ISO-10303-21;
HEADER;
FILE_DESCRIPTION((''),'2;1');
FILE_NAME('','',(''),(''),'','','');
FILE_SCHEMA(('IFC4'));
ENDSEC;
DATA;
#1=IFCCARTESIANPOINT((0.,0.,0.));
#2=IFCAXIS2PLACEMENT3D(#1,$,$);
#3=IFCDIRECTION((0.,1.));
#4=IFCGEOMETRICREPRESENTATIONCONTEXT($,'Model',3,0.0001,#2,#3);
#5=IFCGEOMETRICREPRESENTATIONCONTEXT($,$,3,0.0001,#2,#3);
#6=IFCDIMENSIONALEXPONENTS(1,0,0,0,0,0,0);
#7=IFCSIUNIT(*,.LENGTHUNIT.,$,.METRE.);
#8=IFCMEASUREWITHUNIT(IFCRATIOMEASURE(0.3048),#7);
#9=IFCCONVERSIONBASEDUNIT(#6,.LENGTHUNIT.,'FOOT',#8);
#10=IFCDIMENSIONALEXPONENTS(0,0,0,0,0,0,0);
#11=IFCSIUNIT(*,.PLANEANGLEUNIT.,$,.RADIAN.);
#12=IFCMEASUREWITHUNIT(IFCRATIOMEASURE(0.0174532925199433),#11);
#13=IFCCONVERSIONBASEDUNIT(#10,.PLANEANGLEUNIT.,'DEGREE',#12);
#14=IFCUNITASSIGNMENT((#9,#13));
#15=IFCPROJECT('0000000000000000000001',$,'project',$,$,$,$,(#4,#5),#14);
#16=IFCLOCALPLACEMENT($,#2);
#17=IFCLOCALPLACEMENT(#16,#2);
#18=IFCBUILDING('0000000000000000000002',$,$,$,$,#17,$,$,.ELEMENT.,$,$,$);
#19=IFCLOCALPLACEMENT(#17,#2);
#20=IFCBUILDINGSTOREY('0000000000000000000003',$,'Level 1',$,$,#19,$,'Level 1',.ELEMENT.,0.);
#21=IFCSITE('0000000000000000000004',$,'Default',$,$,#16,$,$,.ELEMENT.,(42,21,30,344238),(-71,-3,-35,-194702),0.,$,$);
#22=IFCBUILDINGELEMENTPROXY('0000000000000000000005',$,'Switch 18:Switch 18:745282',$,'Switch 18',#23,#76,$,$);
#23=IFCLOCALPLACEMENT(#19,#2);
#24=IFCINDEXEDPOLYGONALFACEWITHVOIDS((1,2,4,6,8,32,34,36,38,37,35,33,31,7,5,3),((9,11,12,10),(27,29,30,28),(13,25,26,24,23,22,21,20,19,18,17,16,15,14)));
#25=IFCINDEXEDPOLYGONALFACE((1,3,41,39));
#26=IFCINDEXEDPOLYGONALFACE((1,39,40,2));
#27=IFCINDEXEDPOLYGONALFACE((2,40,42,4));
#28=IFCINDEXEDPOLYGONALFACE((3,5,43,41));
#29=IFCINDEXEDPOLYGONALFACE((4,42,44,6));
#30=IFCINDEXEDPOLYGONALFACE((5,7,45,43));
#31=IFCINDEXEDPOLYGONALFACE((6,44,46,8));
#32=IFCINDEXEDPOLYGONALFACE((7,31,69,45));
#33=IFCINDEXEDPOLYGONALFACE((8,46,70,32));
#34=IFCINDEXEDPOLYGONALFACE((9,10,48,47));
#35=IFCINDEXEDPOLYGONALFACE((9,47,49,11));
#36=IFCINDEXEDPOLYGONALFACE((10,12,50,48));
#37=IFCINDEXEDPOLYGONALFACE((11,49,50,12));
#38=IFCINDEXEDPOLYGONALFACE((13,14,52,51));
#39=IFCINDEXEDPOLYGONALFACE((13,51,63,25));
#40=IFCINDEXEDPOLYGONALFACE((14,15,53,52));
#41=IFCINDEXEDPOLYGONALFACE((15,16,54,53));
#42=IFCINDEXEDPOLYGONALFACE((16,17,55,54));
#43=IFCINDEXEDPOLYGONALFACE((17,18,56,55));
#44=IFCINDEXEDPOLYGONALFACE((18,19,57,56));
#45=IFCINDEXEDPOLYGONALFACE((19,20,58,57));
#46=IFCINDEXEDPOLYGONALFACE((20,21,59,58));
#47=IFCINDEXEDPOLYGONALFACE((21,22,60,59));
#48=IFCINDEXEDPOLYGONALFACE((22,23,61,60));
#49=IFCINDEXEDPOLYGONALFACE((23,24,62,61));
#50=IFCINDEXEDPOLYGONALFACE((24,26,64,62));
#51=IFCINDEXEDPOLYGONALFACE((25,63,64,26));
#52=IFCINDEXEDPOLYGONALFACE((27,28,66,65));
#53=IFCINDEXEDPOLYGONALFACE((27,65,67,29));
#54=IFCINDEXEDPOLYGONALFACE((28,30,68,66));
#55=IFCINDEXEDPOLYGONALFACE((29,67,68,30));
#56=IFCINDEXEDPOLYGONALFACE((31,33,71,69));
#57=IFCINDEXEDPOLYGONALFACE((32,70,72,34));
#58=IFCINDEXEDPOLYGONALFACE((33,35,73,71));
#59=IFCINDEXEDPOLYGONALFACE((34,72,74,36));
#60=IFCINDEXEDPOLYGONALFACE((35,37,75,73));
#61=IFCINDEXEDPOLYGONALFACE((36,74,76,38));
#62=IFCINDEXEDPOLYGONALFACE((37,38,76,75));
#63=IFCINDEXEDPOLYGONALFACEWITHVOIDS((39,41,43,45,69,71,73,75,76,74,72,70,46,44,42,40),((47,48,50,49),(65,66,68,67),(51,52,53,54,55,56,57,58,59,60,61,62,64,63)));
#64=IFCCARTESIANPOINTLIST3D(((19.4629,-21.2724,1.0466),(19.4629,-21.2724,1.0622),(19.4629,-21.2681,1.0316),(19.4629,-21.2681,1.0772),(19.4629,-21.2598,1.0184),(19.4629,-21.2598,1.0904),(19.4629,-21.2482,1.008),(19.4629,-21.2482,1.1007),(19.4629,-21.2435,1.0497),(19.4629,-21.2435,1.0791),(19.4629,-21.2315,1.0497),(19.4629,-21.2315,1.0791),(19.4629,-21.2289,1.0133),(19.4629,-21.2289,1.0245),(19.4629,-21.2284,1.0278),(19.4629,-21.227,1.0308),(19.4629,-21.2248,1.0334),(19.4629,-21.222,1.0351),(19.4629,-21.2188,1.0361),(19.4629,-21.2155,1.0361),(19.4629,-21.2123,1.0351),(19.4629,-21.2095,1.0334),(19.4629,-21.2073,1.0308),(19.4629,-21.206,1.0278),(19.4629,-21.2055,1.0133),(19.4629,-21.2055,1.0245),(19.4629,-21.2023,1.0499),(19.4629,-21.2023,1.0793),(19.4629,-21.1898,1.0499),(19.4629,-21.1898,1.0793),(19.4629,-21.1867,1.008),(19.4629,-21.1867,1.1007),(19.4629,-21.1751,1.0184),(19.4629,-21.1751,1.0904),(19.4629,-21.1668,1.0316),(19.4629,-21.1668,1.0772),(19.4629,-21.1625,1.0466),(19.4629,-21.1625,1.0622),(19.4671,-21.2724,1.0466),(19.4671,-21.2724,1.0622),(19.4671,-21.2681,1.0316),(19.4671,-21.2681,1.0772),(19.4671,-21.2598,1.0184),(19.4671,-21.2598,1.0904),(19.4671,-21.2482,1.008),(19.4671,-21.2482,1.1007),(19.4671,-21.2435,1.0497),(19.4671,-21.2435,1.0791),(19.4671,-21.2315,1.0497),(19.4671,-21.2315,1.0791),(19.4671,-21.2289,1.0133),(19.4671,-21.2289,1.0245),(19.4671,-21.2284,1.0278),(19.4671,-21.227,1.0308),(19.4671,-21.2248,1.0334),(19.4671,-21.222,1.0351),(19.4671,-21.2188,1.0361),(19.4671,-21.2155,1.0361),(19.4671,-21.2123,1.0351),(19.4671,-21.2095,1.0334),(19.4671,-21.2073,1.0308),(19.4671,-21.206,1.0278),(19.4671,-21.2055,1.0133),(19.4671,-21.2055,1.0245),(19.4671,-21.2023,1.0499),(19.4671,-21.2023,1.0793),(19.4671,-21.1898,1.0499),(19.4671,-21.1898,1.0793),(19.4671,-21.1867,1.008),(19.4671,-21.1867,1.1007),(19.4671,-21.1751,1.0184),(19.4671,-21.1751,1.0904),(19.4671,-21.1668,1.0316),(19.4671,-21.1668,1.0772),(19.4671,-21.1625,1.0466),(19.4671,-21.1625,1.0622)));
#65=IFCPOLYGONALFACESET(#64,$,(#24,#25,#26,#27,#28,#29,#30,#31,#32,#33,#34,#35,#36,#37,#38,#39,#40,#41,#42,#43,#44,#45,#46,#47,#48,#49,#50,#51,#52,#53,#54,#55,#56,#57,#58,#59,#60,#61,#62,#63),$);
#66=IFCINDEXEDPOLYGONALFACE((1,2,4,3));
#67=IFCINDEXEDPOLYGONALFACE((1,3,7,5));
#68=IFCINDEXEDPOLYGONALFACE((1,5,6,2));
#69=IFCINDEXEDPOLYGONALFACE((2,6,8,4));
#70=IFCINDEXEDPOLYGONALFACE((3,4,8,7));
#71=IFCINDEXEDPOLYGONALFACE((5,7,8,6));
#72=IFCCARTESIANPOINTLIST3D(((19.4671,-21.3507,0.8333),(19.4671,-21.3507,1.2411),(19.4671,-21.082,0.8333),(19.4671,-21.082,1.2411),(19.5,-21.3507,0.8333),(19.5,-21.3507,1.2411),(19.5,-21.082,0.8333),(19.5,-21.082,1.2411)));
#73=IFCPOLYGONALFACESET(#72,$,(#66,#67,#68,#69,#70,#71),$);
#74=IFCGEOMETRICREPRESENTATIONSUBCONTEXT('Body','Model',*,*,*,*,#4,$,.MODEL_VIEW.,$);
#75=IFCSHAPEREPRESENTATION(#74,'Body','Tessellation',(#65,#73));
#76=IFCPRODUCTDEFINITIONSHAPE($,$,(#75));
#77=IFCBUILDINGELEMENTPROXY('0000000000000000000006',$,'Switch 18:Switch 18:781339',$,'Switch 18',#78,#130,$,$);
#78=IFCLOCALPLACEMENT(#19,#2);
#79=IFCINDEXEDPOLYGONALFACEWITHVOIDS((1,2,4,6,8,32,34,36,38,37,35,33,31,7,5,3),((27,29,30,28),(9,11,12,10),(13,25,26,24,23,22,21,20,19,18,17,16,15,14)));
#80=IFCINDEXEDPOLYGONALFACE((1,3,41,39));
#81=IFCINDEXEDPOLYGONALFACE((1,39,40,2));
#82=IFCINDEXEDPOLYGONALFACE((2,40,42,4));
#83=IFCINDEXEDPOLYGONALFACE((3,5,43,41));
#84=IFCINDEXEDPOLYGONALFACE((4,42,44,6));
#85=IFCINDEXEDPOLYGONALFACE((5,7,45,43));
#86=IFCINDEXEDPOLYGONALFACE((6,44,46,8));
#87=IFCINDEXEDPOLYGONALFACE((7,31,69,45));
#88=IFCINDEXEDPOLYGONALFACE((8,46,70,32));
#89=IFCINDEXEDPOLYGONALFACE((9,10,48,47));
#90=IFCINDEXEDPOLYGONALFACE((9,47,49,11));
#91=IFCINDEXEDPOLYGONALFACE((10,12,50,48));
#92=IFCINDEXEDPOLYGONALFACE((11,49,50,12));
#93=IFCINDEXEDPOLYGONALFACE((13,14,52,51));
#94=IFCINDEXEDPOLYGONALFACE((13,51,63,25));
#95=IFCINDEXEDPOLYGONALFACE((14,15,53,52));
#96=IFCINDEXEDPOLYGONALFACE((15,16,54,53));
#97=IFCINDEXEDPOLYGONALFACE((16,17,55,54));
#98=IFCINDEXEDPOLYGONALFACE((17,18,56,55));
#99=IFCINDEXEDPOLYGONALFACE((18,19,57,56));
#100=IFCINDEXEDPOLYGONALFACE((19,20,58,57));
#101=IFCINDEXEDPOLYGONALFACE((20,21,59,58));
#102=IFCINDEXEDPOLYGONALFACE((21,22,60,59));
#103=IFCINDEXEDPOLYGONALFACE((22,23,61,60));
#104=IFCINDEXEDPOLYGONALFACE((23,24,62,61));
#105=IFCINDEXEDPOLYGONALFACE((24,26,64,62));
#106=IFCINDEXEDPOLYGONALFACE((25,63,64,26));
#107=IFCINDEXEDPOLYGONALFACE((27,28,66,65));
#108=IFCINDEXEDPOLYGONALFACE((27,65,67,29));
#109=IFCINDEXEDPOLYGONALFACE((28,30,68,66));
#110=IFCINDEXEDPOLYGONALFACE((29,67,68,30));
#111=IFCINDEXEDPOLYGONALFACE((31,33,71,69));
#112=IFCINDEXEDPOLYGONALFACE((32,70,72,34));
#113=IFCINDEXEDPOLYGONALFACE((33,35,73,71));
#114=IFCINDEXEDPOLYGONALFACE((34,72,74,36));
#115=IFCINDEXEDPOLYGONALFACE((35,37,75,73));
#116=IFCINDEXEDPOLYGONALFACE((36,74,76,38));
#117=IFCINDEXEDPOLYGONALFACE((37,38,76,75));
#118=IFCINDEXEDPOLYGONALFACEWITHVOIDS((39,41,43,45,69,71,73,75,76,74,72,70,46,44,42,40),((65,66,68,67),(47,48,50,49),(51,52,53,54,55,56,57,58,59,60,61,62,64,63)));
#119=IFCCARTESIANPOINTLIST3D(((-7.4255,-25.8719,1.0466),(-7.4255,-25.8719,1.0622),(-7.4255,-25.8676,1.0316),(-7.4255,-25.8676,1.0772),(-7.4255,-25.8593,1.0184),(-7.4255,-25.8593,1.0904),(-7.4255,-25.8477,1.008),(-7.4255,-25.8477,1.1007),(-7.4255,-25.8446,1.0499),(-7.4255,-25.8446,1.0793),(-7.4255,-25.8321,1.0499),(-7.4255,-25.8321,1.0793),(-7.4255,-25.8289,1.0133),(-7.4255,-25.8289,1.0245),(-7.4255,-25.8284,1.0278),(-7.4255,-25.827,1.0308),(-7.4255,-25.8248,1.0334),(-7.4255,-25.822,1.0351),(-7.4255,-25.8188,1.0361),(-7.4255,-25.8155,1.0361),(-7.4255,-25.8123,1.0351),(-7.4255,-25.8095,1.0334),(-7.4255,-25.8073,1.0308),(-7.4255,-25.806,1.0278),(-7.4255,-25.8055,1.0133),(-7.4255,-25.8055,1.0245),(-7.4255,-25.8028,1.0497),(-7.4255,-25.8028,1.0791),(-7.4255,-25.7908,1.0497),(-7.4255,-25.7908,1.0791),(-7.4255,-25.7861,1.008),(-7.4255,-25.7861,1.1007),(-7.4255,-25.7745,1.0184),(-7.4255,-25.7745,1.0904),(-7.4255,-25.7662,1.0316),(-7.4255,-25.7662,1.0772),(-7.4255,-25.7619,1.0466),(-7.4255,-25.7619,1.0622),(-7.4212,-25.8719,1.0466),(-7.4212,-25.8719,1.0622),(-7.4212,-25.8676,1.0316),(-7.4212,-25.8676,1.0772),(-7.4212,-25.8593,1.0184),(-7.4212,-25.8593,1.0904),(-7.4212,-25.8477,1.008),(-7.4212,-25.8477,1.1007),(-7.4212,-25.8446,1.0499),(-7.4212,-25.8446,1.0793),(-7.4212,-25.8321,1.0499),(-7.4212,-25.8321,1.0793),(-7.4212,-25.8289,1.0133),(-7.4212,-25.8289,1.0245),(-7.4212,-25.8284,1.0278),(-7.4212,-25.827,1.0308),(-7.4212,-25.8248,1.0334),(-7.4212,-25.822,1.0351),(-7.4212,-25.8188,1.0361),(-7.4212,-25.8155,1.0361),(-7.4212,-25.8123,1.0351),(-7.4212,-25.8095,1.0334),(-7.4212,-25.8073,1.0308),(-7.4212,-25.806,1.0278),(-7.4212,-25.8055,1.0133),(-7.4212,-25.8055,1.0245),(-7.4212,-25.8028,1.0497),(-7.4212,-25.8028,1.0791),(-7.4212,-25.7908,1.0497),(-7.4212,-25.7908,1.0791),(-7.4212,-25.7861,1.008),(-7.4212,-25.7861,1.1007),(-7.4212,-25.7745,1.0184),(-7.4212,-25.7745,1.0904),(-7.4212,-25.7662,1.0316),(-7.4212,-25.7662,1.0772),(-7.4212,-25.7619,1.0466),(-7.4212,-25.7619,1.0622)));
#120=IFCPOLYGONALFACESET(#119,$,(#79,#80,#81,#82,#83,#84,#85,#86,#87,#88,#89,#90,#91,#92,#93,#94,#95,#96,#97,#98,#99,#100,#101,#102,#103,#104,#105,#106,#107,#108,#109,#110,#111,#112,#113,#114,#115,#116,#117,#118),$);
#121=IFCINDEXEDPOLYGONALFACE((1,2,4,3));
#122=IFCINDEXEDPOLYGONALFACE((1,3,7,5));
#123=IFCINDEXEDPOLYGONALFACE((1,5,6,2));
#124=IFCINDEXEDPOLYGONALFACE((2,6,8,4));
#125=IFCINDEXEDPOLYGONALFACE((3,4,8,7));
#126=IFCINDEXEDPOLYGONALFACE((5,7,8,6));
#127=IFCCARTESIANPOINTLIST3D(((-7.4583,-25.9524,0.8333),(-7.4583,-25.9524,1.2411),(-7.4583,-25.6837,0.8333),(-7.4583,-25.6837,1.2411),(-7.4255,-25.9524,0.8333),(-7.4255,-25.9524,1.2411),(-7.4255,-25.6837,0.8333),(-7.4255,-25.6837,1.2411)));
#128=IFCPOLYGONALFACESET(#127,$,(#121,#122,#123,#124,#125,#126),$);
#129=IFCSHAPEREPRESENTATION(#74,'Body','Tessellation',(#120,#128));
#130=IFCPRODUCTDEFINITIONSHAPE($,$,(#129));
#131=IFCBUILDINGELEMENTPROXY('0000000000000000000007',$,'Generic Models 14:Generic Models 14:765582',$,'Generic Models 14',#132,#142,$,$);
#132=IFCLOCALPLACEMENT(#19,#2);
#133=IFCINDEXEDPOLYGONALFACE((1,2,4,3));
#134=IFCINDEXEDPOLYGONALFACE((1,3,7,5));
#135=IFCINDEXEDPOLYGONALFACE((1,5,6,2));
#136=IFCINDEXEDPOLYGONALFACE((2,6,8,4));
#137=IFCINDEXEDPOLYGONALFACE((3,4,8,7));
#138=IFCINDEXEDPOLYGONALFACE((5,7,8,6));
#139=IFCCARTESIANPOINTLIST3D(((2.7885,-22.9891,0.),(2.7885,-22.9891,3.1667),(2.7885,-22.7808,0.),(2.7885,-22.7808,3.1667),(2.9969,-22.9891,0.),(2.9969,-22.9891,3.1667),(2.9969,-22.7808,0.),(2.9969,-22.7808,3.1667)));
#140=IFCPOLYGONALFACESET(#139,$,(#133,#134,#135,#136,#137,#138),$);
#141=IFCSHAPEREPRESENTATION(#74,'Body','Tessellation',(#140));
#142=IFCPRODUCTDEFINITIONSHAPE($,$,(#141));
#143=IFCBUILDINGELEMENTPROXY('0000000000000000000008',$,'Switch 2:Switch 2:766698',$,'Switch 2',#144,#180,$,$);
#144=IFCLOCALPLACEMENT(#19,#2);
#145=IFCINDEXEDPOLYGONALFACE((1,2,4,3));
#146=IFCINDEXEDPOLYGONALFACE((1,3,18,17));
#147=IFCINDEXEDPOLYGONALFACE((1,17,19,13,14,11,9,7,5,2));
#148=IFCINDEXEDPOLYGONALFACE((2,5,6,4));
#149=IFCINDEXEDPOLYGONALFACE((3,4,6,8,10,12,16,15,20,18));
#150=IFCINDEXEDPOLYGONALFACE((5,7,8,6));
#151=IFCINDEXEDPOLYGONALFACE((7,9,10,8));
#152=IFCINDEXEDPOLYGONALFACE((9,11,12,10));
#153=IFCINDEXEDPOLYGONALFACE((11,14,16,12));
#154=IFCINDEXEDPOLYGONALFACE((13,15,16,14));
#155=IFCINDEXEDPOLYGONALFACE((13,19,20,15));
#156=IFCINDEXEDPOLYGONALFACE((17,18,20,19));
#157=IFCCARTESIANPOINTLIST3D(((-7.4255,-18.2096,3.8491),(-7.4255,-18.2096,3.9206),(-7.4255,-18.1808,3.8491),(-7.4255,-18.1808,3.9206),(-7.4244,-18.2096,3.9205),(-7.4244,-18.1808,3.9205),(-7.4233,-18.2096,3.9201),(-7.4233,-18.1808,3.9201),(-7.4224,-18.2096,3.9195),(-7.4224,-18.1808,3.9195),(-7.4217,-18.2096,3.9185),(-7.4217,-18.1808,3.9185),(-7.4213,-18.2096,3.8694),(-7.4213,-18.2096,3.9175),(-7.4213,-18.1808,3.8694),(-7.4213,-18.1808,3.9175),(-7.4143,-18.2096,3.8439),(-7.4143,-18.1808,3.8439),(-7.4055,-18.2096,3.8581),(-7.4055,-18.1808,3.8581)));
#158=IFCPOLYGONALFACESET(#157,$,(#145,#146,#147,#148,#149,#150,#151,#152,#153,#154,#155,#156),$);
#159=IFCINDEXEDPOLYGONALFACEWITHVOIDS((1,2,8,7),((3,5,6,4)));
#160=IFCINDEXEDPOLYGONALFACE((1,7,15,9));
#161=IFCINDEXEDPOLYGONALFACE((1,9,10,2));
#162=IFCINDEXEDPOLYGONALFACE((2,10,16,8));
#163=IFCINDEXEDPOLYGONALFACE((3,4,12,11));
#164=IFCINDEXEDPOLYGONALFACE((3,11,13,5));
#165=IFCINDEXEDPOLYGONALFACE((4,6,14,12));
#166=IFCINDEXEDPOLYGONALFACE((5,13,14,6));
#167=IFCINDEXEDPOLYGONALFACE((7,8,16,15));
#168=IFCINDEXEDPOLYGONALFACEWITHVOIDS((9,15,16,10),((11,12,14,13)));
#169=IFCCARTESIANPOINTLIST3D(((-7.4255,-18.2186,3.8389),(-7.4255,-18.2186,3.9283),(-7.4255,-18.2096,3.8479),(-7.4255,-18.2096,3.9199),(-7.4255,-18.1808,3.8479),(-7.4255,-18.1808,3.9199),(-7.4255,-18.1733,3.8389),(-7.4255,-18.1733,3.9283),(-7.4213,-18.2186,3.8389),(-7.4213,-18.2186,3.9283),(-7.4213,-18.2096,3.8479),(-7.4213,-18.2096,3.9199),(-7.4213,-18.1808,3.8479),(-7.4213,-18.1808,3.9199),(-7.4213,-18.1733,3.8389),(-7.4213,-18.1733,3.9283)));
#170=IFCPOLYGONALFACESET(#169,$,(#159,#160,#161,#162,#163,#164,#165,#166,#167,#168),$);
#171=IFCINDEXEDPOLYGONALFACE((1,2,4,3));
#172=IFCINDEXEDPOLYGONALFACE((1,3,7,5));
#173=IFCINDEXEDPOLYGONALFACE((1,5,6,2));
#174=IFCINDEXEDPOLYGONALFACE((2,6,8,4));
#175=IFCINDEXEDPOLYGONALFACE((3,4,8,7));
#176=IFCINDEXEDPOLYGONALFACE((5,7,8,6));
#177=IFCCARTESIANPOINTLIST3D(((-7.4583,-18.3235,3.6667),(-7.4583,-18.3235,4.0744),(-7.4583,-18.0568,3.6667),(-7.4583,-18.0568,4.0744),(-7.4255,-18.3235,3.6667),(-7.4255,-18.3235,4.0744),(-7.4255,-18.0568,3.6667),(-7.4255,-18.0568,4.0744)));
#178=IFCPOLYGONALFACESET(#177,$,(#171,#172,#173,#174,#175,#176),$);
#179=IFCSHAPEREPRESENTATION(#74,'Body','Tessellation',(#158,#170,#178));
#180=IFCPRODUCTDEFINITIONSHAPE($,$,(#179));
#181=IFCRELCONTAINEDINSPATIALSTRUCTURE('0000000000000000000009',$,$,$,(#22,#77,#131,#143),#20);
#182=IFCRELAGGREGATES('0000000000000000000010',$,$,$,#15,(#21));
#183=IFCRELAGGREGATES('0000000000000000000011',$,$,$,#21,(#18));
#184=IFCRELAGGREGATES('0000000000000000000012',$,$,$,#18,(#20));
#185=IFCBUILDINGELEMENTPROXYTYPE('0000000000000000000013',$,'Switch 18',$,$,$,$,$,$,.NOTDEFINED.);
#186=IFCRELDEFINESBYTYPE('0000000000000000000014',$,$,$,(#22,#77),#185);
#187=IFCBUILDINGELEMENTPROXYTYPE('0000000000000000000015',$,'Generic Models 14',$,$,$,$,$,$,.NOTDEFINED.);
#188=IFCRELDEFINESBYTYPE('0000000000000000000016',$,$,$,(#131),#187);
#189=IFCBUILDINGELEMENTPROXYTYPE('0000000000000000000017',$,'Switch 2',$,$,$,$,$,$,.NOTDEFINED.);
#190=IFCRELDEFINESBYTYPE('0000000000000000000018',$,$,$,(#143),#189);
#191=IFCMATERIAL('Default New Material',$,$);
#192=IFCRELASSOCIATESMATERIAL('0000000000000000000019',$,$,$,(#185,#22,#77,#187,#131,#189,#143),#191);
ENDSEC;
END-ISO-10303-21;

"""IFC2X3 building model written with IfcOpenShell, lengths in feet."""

from ifc_helpers import new_model, entity, si_unit, converted_unit, direction, frame, frame_2d, origin, origin_2d_with_axis, place, context, subcontext, project, spatial, polyline, circle_curve, parameter, trimmed, segment, composite_curve, rectangle, outline, extrude, source, transform, mapped, material, type_object, type_shapes, element, save


model = new_model("IFC2X3")

# Units and contexts
model_context = context("Model", 3, precision=0.0001, world=origin(), true_north=direction((0.0, 1.0)))
context_of_model = context(None, 3, precision=0.0001, world=origin(), true_north=direction((0.0, 1.0)))
body_context = subcontext(model_context, "Body", "Model", "MODEL_VIEW")
ifc_project = project(units=[converted_unit("LENGTHUNIT", "FOOT", entity("IfcRatioMeasure", 0.3048), si_unit("LENGTHUNIT", "METRE"), dimensions=[1, 0, 0, 0, 0, 0, 0]), converted_unit("PLANEANGLEUNIT", "DEGREE", entity("IfcRatioMeasure", 0.0174532925199433), si_unit("PLANEANGLEUNIT", "RADIAN"), dimensions=[0, 0, 0, 0, 0, 0, 0])], contexts=[model_context, context_of_model])

# Site, building, storey
site_placement = place(None, origin())
site = spatial("IfcSite", under=ifc_project, at=site_placement, Name="Default", CompositionType="ELEMENT", RefLatitude=(42, 21, 30, 344238), RefLongitude=(-71, -3, -35, -194702), RefElevation=0.0)
building_placement = place(site_placement, origin())
building = spatial("IfcBuilding", under=site, at=building_placement, CompositionType="ELEMENT")
storey_placement = place(building_placement, origin())
storey = spatial("IfcBuildingStorey", under=building, at=storey_placement, Name="Level 1", LongName="Level 1", CompositionType="ELEMENT", Elevation=0.0)

# Shared definitions
ifc_material = material(Name="Default New Material")

# Building element proxies
building_element_proxy_type_1 = type_object("IfcBuildingElementProxyType", Name="Switch 18", PredefinedType="NOTDEFINED", material=ifc_material)
shared_shape_1 = source(origin(), body_context, "Body", "SweptSolid", [
    extrude(outline(composite_curve([segment(polyline([(-0.0308, -0.0464), (0.0308, -0.0464)]), True, "CONTINUOUS"), segment(trimmed(circle_curve(frame_2d((-0.0003, 0.0), x_axis=(-1.0, 0.0)), 0.0558), [parameter(123.794741)], [parameter(236.205259)], True, "PARAMETER"), True, "CONTINUOUS"), segment(polyline([(0.0308, 0.0464), (-0.0308, 0.0464)]), True, "CONTINUOUS"), segment(trimmed(circle_curve(frame_2d((0.0003, 0.0), x_axis=(1.0, 0.0)), 0.0558), [parameter(123.794741)], [parameter(236.205259)], True, "PARAMETER"), True, "CONTINUOUS")], self_intersect=False), holes=[polyline([(0.0141, 0.0247), (0.026, 0.0247), (0.026, -0.0047), (0.0141, -0.0047), (0.0141, 0.0247)]), polyline([(-0.0152, 0.0249), (-0.0152, -0.0045), (-0.0277, -0.0045), (-0.0277, 0.0249), (-0.0152, 0.0249)]), composite_curve([segment(polyline([(-0.012, -0.0411), (-0.012, -0.0299)]), True, "CONTINUOUS"), segment(trimmed(circle_curve(frame_2d((-0.0003, -0.0299), x_axis=(-1.0, 0.0)), 0.0117), [parameter(180.0)], [parameter(0.0)], True, "PARAMETER"), False, "CONTINUOUS"), segment(polyline([(0.0114, -0.0299), (0.0114, -0.0411)]), True, "CONTINUOUS"), segment(polyline([(0.0114, -0.0411), (-0.012, -0.0411)]), True, "CONTINUOUS")], self_intersect=False)]), frame((-0.0011, 0.0329, 0.2211), z_axis=(0.0, 1.0, 0.0), x_axis=(-1.0, 0.0, 0.0)), (0.0, 0.0, 1.0), 0.0042),
    extrude(rectangle(XDim=0.0329, YDim=0.2687, at=origin_2d_with_axis()), frame((0.0, 0.0164, 0.0), z_axis=(0.0, 0.0, 1.0), x_axis=(0.0, -1.0, 0.0)), (0.0, 0.0, 1.0), 0.4078),
])
type_shapes(building_element_proxy_type_1, [shared_shape_1])
for number, where, z_axis, x_axis, name in (
    (1, (19.5, -21.2163, 0.8333), (0.0, 0.0, 1.0), (0.0, 1.0, 0.0), "Switch 18:Switch 18:745282"),
    (2, (-7.4583, -25.818, 0.8333), (0.0, 0.0, 1.0), (0.0, -1.0, 0.0), "Switch 18:Switch 18:781339"),
):
    element("IfcBuildingElementProxy", number, at=place(storey_placement, frame(where, z_axis=z_axis, x_axis=x_axis)), inside=storey, type_object=building_element_proxy_type_1, material=ifc_material, Name=name, ObjectType="Switch 18", context=body_context, shape_type="MappedRepresentation", body=[
        mapped(shared_shape_1, transform((0.0, 0.0, 0.0), scale=1.0)),
    ])
building_element_proxy_type_2 = type_object("IfcBuildingElementProxyType", Name="Generic Models 14", PredefinedType="NOTDEFINED", material=ifc_material)
shared_shape_2 = source(origin(), body_context, "Body", "SweptSolid", [
    extrude(rectangle(XDim=0.2083, YDim=0.2083, at=frame_2d((0.0, 0.0), x_axis=(1.0, 0.0))), frame((0.1042, 0.1042, 0.0), z_axis=(0.0, 0.0, 1.0), x_axis=(0.0, 1.0, 0.0)), (0.0, 0.0, 1.0), 3.1667),
])
type_shapes(building_element_proxy_type_2, [shared_shape_2])
proxy_1_placement = place(storey_placement, frame((2.7885, -22.9891, 0.0)))
element("IfcBuildingElementProxy", 3, at=proxy_1_placement, inside=storey, type_object=building_element_proxy_type_2, material=ifc_material, Name="Generic Models 14:Generic Models 14:765582", ObjectType="Generic Models 14", context=body_context, shape_type="MappedRepresentation", body=[
    mapped(shared_shape_2, transform((0.0, 0.0, 0.0), scale=1.0)),
])
building_element_proxy_type_3 = type_object("IfcBuildingElementProxyType", Name="Switch 2", PredefinedType="NOTDEFINED", material=ifc_material)
shared_shape_3 = source(origin(), body_context, "Body", "SweptSolid", [
    extrude(outline(composite_curve([segment(polyline([(-0.0252, -0.0211), (-0.0084, -0.0211)]), True, "CONTINUOUS"), segment(polyline([(-0.0084, -0.0211), (-0.0073, -0.0017)]), True, "CONTINUOUS"), segment(polyline([(-0.0073, -0.0017), (0.0336, 0.0237)]), True, "CONTINUOUS"), segment(trimmed(circle_curve(frame_2d((0.0308, 0.0266), x_axis=(0.848706, 0.528865)), 0.004), [parameter(281.689503)], [parameter(4.471238)], True, "PARAMETER"), True, "CONTINUOUS"), segment(polyline([(0.034, 0.029), (-0.0267, -0.0088)]), True, "CONTINUOUS"), segment(polyline([(-0.0267, -0.0088), (-0.0252, -0.0211)]), True, "CONTINUOUS")], self_intersect=False)), frame((-0.0093, 0.0394, 0.2098), z_axis=(1.0, 0.0, 0.0), x_axis=(0.0, 0.528865, 0.848706)), (0.0, 0.0, 1.0), 0.0287),
    extrude(outline(polyline([(-0.0447, -0.0227), (0.0447, -0.0227), (0.0447, 0.0227), (-0.0447, 0.0227), (-0.0447, -0.0227)]), holes=[polyline([(-0.0364, -0.0136), (-0.0364, 0.0151), (0.0357, 0.0151), (0.0357, -0.0136), (-0.0364, -0.0136)])]), frame((0.0058, 0.0328, 0.2169), z_axis=(0.0, 1.0, 0.0), x_axis=(0.0, 0.0, -1.0)), (0.0, 0.0, 1.0), 0.0042),
    extrude(rectangle(XDim=0.0328, YDim=0.2667, at=origin_2d_with_axis()), frame((0.0, 0.0164, 0.0), z_axis=(0.0, 0.0, 1.0), x_axis=(0.0, -1.0, 0.0)), (0.0, 0.0, 1.0), 0.4078),
])
type_shapes(building_element_proxy_type_3, [shared_shape_3])
proxy_2_placement = place(storey_placement, frame((-7.4583, -18.1901, 3.6667), z_axis=(0.0, 0.0, 1.0), x_axis=(0.0, -1.0, 0.0)))
element("IfcBuildingElementProxy", 4, at=proxy_2_placement, inside=storey, type_object=building_element_proxy_type_3, material=ifc_material, Name="Switch 2:Switch 2:766698", ObjectType="Switch 2", context=body_context, shape_type="MappedRepresentation", body=[
    mapped(shared_shape_3, transform((0.0, 0.0, 0.0), scale=1.0)),
])

save(model, "model.ifc")
